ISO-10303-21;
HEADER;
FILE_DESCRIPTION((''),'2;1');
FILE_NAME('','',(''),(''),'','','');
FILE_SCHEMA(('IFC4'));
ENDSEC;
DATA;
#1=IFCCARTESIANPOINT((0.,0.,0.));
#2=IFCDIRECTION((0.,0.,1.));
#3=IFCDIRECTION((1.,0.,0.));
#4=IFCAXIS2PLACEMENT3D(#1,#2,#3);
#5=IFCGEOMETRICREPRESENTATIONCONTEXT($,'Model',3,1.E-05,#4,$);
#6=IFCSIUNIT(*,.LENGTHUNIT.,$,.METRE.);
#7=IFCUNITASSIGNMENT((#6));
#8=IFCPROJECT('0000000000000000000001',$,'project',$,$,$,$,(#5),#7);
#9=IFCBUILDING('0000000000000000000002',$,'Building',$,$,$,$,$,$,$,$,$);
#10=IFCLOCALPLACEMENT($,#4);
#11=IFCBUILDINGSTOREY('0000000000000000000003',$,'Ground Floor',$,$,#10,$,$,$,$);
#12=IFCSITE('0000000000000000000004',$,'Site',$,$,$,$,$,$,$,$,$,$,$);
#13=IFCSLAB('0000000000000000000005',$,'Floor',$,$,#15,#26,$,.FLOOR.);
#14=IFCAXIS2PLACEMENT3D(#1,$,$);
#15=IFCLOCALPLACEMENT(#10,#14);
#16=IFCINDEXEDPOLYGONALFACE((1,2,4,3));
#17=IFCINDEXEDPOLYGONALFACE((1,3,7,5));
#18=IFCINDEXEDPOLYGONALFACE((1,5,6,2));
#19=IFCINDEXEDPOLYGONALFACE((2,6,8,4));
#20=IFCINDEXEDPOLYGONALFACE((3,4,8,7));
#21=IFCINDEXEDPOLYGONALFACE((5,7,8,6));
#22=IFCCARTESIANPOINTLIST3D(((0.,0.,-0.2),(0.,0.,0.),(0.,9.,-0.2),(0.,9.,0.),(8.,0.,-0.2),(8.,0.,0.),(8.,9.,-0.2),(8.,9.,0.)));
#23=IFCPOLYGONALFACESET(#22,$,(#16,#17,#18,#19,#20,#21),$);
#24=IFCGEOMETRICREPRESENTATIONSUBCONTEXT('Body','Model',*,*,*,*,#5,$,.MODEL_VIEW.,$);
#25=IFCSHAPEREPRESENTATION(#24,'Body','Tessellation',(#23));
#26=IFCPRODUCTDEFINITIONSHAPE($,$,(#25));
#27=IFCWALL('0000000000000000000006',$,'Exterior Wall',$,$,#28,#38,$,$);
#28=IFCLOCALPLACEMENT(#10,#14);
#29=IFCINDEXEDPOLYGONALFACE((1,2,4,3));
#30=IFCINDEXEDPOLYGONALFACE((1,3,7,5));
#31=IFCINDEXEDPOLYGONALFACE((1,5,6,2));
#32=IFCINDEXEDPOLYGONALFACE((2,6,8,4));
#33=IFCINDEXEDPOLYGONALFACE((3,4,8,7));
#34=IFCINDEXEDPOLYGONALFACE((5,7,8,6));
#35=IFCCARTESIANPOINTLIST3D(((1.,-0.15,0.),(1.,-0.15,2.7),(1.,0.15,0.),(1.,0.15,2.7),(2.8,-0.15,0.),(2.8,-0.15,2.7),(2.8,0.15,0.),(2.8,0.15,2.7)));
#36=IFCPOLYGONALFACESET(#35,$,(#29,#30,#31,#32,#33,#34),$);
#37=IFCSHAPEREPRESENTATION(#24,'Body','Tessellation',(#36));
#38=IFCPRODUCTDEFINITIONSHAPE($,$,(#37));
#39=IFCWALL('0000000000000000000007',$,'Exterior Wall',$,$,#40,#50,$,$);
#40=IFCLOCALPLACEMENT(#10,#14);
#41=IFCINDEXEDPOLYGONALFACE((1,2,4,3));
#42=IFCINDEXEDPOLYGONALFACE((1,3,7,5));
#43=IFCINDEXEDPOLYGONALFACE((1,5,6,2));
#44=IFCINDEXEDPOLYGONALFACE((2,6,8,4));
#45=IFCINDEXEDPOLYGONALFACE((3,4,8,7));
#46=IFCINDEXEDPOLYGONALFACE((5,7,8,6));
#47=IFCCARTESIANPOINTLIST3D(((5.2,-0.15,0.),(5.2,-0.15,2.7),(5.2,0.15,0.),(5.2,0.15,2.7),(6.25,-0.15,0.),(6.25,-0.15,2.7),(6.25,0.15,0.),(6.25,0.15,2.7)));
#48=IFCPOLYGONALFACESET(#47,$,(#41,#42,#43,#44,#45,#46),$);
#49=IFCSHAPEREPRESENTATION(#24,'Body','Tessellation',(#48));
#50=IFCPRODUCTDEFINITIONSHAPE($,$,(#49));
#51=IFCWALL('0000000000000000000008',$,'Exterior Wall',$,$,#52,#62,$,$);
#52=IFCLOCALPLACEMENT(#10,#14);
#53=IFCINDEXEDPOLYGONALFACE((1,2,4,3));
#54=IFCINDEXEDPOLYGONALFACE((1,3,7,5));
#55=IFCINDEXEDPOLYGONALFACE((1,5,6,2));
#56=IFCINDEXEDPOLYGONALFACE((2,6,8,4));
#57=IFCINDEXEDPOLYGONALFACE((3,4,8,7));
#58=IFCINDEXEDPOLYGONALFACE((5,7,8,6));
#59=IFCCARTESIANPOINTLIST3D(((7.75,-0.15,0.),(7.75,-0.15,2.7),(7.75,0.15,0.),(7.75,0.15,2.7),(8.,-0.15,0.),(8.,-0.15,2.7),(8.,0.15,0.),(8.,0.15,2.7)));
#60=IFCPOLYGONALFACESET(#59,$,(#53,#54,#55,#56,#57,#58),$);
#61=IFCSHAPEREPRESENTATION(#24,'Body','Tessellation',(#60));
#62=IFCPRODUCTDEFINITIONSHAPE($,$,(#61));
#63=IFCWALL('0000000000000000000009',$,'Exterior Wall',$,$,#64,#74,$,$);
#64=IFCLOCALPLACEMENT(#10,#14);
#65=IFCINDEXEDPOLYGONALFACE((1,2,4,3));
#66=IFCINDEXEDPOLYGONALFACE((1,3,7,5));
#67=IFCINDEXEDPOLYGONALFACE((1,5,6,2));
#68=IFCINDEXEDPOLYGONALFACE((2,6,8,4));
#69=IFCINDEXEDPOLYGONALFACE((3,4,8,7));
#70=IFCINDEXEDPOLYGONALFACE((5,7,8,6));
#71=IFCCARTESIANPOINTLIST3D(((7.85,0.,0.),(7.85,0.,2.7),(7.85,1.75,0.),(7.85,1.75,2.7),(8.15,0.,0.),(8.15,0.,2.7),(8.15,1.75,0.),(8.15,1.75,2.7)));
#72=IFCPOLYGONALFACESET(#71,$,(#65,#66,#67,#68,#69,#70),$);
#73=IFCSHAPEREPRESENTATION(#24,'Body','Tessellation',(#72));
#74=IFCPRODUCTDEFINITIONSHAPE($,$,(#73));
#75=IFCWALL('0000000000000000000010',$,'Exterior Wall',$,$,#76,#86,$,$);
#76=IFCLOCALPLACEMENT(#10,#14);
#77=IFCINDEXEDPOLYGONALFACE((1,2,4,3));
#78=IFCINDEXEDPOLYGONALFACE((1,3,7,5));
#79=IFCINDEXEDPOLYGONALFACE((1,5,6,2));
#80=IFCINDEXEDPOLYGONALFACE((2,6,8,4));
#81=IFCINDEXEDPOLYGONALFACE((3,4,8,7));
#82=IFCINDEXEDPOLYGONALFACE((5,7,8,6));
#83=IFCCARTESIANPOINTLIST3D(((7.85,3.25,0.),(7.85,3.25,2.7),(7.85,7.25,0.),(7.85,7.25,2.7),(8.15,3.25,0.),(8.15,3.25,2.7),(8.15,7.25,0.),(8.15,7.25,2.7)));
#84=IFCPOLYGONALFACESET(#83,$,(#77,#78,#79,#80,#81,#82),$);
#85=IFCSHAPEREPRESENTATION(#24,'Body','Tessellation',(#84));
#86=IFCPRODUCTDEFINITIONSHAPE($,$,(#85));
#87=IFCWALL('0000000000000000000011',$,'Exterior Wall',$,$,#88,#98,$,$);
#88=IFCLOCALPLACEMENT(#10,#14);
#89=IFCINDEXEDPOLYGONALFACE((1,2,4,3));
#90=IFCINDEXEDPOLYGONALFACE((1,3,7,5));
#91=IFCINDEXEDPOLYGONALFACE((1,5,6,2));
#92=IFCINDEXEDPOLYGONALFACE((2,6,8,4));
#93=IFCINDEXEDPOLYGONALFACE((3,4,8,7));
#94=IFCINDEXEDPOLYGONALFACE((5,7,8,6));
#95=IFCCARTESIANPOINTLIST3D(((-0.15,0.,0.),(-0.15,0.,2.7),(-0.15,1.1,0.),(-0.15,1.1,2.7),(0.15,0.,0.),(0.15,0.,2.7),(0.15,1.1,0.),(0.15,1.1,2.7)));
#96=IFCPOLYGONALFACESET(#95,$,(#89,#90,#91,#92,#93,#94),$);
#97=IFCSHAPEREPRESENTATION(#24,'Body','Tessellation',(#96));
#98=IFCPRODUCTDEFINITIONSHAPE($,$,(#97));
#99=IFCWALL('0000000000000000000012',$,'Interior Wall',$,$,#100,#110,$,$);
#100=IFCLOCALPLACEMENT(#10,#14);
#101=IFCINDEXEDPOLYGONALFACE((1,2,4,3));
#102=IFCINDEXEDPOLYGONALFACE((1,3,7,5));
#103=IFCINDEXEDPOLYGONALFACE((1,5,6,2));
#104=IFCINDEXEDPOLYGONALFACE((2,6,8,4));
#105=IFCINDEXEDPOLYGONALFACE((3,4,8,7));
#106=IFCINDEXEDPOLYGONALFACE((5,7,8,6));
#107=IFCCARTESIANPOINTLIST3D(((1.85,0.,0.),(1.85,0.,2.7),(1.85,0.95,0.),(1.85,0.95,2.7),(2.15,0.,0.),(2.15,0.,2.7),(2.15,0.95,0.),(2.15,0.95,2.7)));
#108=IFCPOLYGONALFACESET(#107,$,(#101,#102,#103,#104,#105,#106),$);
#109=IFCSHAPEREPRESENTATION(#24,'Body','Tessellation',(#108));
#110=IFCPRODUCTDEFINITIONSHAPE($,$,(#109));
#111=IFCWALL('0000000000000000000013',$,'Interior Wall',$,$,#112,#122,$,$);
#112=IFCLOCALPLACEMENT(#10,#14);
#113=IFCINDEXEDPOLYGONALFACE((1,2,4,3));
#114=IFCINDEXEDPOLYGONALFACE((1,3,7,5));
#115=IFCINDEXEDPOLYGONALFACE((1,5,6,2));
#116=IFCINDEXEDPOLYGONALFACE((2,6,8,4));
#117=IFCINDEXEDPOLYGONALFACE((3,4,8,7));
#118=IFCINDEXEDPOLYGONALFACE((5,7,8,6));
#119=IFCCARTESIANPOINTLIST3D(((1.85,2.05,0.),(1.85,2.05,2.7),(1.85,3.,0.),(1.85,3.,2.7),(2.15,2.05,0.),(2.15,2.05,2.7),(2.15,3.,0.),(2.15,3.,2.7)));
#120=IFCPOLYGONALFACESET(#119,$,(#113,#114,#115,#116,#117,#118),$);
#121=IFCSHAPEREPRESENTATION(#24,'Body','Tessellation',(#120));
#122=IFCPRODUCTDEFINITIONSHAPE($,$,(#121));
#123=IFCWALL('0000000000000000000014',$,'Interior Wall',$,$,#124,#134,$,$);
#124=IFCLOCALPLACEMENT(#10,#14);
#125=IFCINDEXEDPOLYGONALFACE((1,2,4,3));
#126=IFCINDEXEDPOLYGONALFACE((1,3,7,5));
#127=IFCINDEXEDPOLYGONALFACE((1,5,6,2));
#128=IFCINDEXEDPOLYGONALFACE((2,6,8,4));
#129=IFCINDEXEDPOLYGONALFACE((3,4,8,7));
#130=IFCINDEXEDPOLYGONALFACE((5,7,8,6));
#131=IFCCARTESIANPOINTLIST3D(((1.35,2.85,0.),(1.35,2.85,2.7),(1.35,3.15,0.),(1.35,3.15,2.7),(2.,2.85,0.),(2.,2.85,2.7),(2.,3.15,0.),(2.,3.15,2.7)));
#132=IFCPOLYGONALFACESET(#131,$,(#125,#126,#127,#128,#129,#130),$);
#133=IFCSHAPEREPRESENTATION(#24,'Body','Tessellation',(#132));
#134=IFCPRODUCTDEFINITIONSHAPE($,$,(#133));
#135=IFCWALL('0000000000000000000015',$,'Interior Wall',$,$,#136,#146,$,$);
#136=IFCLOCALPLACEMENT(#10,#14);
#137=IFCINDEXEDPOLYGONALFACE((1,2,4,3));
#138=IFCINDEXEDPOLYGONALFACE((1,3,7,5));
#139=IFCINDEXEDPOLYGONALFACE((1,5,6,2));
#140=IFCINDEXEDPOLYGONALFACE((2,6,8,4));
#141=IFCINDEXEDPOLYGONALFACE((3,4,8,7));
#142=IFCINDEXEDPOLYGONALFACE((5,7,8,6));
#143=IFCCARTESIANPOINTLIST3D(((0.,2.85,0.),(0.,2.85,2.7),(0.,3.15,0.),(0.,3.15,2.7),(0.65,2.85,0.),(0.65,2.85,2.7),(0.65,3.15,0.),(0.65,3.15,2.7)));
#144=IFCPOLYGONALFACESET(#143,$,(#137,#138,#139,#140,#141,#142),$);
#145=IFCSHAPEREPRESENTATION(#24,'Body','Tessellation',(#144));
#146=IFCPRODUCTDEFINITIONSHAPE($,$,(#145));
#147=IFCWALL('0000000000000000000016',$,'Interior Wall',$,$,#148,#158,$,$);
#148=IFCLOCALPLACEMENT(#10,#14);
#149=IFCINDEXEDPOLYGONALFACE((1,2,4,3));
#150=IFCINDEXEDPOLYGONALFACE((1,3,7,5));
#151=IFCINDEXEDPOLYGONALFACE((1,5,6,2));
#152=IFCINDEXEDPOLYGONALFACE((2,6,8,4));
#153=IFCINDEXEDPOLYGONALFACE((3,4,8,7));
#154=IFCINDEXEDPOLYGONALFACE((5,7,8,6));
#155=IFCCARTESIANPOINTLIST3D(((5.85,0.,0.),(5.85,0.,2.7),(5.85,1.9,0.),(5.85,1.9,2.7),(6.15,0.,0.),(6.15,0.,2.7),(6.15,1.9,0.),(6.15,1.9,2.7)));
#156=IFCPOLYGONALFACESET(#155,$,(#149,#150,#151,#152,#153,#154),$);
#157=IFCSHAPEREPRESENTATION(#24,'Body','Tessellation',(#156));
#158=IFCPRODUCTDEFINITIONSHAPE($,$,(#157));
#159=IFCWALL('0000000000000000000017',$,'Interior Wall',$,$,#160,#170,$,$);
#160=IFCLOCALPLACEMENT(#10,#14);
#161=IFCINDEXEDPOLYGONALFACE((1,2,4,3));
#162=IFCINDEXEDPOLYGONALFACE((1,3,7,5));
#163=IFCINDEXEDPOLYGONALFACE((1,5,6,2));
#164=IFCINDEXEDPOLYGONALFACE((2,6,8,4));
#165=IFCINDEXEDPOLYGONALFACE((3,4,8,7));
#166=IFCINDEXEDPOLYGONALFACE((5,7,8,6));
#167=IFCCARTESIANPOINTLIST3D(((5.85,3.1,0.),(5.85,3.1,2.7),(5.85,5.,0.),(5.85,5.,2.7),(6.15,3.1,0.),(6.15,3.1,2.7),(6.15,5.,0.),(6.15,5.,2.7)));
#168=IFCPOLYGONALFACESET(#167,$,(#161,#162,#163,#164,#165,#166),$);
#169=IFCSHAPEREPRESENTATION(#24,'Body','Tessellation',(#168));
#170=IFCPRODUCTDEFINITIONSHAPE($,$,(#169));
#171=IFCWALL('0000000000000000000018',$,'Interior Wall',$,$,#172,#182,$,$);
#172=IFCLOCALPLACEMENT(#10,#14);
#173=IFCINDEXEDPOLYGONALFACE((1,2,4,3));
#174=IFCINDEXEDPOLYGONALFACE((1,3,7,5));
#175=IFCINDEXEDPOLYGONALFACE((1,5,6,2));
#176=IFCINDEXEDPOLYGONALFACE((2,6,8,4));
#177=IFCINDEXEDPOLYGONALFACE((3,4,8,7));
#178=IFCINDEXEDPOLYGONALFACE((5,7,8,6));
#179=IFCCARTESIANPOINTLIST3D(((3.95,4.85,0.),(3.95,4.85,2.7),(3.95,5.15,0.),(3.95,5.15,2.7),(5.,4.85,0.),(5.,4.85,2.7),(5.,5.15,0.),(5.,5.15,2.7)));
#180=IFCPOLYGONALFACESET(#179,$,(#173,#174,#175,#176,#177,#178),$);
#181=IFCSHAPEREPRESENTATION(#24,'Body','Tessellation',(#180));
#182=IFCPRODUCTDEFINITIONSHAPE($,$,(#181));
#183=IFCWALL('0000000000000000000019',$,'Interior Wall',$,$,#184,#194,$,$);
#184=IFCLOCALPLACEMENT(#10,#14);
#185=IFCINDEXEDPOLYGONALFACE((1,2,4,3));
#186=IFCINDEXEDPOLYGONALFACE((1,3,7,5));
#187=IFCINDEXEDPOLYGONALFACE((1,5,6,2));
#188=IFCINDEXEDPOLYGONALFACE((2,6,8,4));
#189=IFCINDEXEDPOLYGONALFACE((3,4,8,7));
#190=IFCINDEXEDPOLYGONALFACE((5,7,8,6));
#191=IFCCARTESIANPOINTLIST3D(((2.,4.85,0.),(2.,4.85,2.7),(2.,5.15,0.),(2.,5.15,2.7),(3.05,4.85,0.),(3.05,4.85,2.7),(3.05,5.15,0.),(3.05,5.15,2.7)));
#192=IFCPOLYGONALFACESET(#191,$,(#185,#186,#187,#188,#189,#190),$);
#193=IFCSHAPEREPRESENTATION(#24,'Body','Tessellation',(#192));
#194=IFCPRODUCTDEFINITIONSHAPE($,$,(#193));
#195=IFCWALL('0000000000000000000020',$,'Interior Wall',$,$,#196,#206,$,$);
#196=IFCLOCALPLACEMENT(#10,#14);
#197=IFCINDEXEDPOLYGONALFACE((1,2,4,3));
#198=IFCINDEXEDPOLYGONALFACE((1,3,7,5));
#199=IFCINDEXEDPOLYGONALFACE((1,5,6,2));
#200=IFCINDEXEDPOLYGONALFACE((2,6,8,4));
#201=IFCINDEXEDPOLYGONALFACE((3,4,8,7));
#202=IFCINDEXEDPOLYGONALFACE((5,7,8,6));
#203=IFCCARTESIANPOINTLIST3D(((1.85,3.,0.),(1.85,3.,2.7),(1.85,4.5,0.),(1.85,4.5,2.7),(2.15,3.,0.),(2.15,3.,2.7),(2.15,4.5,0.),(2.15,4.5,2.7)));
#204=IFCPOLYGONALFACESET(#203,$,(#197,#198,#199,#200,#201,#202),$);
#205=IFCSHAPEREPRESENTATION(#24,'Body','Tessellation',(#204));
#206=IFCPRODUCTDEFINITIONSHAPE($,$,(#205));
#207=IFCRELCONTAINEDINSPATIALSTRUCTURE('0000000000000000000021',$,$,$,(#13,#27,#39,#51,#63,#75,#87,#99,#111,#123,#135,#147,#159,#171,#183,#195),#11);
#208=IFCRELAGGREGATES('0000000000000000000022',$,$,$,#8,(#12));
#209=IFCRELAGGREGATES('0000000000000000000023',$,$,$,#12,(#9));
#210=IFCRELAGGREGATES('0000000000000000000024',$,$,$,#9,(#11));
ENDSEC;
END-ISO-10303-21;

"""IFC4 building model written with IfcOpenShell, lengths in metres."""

from ifc_helpers import new_model, si_unit, frame, origin_with_axes, place, context, subcontext, project, spatial, indexed_curve, outline, extrude, element, save


model = new_model("IFC4")

# Units and contexts
model_context = context("Model", 3, precision=1e-05, world=origin_with_axes())
body_context = subcontext(model_context, "Body", "Model", "MODEL_VIEW")
ifc_project = project(units=[si_unit("LENGTHUNIT", "METRE")], contexts=[model_context])

# Site, building, storey
site = spatial("IfcSite", under=ifc_project, Name="Site")
building = spatial("IfcBuilding", under=site, Name="Building")
storey_placement = place(None, origin_with_axes())
storey = spatial("IfcBuildingStorey", under=building, at=storey_placement, Name="Ground Floor")

# Slab
slab_placement = place(storey_placement, frame((0.0, 0.0, -0.2), z_axis=(0.0, 0.0, 1.0), x_axis=(1.0, 0.0, 0.0)))
element("IfcSlab", 1, at=slab_placement, inside=storey, Name="Floor", PredefinedType="FLOOR", context=body_context, shape_type="SweptSolid", body=[
    extrude(outline(indexed_curve([(0.0, 0.0), (8.0, 0.0), (8.0, 9.0), (0.0, 9.0)])), None, (0.0, 0.0, 1.0), 0.2),
])

# Walls
wall_1_placement = place(storey_placement, frame((1.0, 0.0, 0.0), z_axis=(0.0, 0.0, 1.0), x_axis=(1.0, 0.0, 0.0)))
element("IfcWall", 2, at=wall_1_placement, inside=storey, Name="Exterior Wall", context=body_context, shape_type="SweptSolid", body=[
    extrude(outline(indexed_curve([(0.0, 0.0), (0.0, 0.3), (1.8, 0.3), (1.8, 0.0), (0.0, 0.0)], self_intersect=False)), frame((0.0, -0.15, 0.0), z_axis=(0.0, 0.0, 1.0), x_axis=(1.0, 0.0, 0.0)), (0.0, 0.0, 1.0), 2.7),
])
wall_2_placement = place(storey_placement, frame((5.2, 0.0, 0.0), z_axis=(0.0, 0.0, 1.0), x_axis=(1.0, 0.0, 0.0)))
element("IfcWall", 3, at=wall_2_placement, inside=storey, Name="Exterior Wall", context=body_context, shape_type="SweptSolid", body=[
    extrude(outline(indexed_curve([(0.0, 0.0), (0.0, 0.3), (1.05, 0.3), (1.05, 0.0), (0.0, 0.0)], self_intersect=False)), frame((0.0, -0.15, 0.0), z_axis=(0.0, 0.0, 1.0), x_axis=(1.0, 0.0, 0.0)), (0.0, 0.0, 1.0), 2.7),
])
wall_3_placement = place(storey_placement, frame((7.75, 0.0, 0.0), z_axis=(0.0, 0.0, 1.0), x_axis=(1.0, 0.0, 0.0)))
element("IfcWall", 4, at=wall_3_placement, inside=storey, Name="Exterior Wall", context=body_context, shape_type="SweptSolid", body=[
    extrude(outline(indexed_curve([(0.0, 0.0), (0.0, 0.3), (0.25, 0.3), (0.25, 0.0), (0.0, 0.0)], self_intersect=False)), frame((0.0, -0.15, 0.0), z_axis=(0.0, 0.0, 1.0), x_axis=(1.0, 0.0, 0.0)), (0.0, 0.0, 1.0), 2.7),
])
wall_4_placement = place(storey_placement, frame((8.0, 0.0, 0.0), z_axis=(0.0, 0.0, 1.0), x_axis=(0.0, 1.0, 0.0)))
element("IfcWall", 5, at=wall_4_placement, inside=storey, Name="Exterior Wall", context=body_context, shape_type="SweptSolid", body=[
    extrude(outline(indexed_curve([(0.0, 0.0), (0.0, 0.3), (1.75, 0.3), (1.75, 0.0), (0.0, 0.0)], self_intersect=False)), frame((0.0, -0.15, 0.0), z_axis=(0.0, 0.0, 1.0), x_axis=(1.0, 0.0, 0.0)), (0.0, 0.0, 1.0), 2.7),
])
wall_5_placement = place(storey_placement, frame((8.0, 3.25, 0.0), z_axis=(0.0, 0.0, 1.0), x_axis=(0.0, 1.0, 0.0)))
element("IfcWall", 6, at=wall_5_placement, inside=storey, Name="Exterior Wall", context=body_context, shape_type="SweptSolid", body=[
    extrude(outline(indexed_curve([(0.0, 0.0), (0.0, 0.3), (4.0, 0.3), (4.0, 0.0), (0.0, 0.0)], self_intersect=False)), frame((0.0, -0.15, 0.0), z_axis=(0.0, 0.0, 1.0), x_axis=(1.0, 0.0, 0.0)), (0.0, 0.0, 1.0), 2.7),
])
wall_6_placement = place(storey_placement, frame((0.0, 1.1, 0.0), z_axis=(0.0, 0.0, 1.0), x_axis=(0.0, -1.0, 0.0)))
element("IfcWall", 7, at=wall_6_placement, inside=storey, Name="Exterior Wall", context=body_context, shape_type="SweptSolid", body=[
    extrude(outline(indexed_curve([(0.0, 0.0), (0.0, 0.3), (1.1, 0.3), (1.1, 0.0), (0.0, 0.0)], self_intersect=False)), frame((0.0, -0.15, 0.0), z_axis=(0.0, 0.0, 1.0), x_axis=(1.0, 0.0, 0.0)), (0.0, 0.0, 1.0), 2.7),
])
wall_7_placement = place(storey_placement, frame((2.0, 0.0, 0.0), z_axis=(0.0, 0.0, 1.0), x_axis=(0.0, 1.0, 0.0)))
element("IfcWall", 8, at=wall_7_placement, inside=storey, Name="Interior Wall", context=body_context, shape_type="SweptSolid", body=[
    extrude(outline(indexed_curve([(0.0, 0.0), (0.0, 0.3), (0.95, 0.3), (0.95, 0.0), (0.0, 0.0)], self_intersect=False)), frame((0.0, -0.15, 0.0), z_axis=(0.0, 0.0, 1.0), x_axis=(1.0, 0.0, 0.0)), (0.0, 0.0, 1.0), 2.7),
])
wall_8_placement = place(storey_placement, frame((2.0, 2.05, 0.0), z_axis=(0.0, 0.0, 1.0), x_axis=(0.0, 1.0, 0.0)))
element("IfcWall", 9, at=wall_8_placement, inside=storey, Name="Interior Wall", context=body_context, shape_type="SweptSolid", body=[
    extrude(outline(indexed_curve([(0.0, 0.0), (0.0, 0.3), (0.95, 0.3), (0.95, 0.0), (0.0, 0.0)], self_intersect=False)), frame((0.0, -0.15, 0.0), z_axis=(0.0, 0.0, 1.0), x_axis=(1.0, 0.0, 0.0)), (0.0, 0.0, 1.0), 2.7),
])
for number, where, z_axis, x_axis, name in (
    (10, (2.0, 3.0, 0.0), (0.0, 0.0, 1.0), (-1.0, 0.0, 0.0), "Interior Wall"),
    (11, (0.65, 3.0, 0.0), (0.0, 0.0, 1.0), (-1.0, 0.0, 0.0), "Interior Wall"),
):
    element("IfcWall", number, at=place(storey_placement, frame(where, z_axis=z_axis, x_axis=x_axis)), inside=storey, Name=name, context=body_context, shape_type="SweptSolid", body=[
        extrude(outline(indexed_curve([(0.0, 0.0), (0.0, 0.3), (0.65, 0.3), (0.65, 0.0), (0.0, 0.0)], self_intersect=False)), frame((0.0, -0.15, 0.0), z_axis=(0.0, 0.0, 1.0), x_axis=(1.0, 0.0, 0.0)), (0.0, 0.0, 1.0), 2.7),
    ])
for number, where, z_axis, x_axis, name in (
    (12, (6.0, 0.0, 0.0), (0.0, 0.0, 1.0), (0.0, 1.0, 0.0), "Interior Wall"),
    (13, (6.0, 3.1, 0.0), (0.0, 0.0, 1.0), (0.0, 1.0, 0.0), "Interior Wall"),
):
    element("IfcWall", number, at=place(storey_placement, frame(where, z_axis=z_axis, x_axis=x_axis)), inside=storey, Name=name, context=body_context, shape_type="SweptSolid", body=[
        extrude(outline(indexed_curve([(0.0, 0.0), (0.0, 0.3), (1.9, 0.3), (1.9, 0.0), (0.0, 0.0)], self_intersect=False)), frame((0.0, -0.15, 0.0), z_axis=(0.0, 0.0, 1.0), x_axis=(1.0, 0.0, 0.0)), (0.0, 0.0, 1.0), 2.7),
    ])
for number, where, z_axis, x_axis, name in (
    (14, (5.0, 5.0, 0.0), (0.0, 0.0, 1.0), (-1.0, 0.0, 0.0), "Interior Wall"),
    (15, (3.05, 5.0, 0.0), (0.0, 0.0, 1.0), (-1.0, 0.0, 0.0), "Interior Wall"),
):
    element("IfcWall", number, at=place(storey_placement, frame(where, z_axis=z_axis, x_axis=x_axis)), inside=storey, Name=name, context=body_context, shape_type="SweptSolid", body=[
        extrude(outline(indexed_curve([(0.0, 0.0), (0.0, 0.3), (1.05, 0.3), (1.05, 0.0), (0.0, 0.0)], self_intersect=False)), frame((0.0, -0.15, 0.0), z_axis=(0.0, 0.0, 1.0), x_axis=(1.0, 0.0, 0.0)), (0.0, 0.0, 1.0), 2.7),
    ])
wall_9_placement = place(storey_placement, frame((2.0, 4.5, 0.0), z_axis=(0.0, 0.0, 1.0), x_axis=(0.0, -1.0, 0.0)))
element("IfcWall", 16, at=wall_9_placement, inside=storey, Name="Interior Wall", context=body_context, shape_type="SweptSolid", body=[
    extrude(outline(indexed_curve([(0.0, 0.0), (0.0, 0.3), (1.5, 0.3), (1.5, 0.0), (0.0, 0.0)], self_intersect=False)), frame((0.0, -0.15, 0.0), z_axis=(0.0, 0.0, 1.0), x_axis=(1.0, 0.0, 0.0)), (0.0, 0.0, 1.0), 2.7),
])

save(model, "model.ifc")
